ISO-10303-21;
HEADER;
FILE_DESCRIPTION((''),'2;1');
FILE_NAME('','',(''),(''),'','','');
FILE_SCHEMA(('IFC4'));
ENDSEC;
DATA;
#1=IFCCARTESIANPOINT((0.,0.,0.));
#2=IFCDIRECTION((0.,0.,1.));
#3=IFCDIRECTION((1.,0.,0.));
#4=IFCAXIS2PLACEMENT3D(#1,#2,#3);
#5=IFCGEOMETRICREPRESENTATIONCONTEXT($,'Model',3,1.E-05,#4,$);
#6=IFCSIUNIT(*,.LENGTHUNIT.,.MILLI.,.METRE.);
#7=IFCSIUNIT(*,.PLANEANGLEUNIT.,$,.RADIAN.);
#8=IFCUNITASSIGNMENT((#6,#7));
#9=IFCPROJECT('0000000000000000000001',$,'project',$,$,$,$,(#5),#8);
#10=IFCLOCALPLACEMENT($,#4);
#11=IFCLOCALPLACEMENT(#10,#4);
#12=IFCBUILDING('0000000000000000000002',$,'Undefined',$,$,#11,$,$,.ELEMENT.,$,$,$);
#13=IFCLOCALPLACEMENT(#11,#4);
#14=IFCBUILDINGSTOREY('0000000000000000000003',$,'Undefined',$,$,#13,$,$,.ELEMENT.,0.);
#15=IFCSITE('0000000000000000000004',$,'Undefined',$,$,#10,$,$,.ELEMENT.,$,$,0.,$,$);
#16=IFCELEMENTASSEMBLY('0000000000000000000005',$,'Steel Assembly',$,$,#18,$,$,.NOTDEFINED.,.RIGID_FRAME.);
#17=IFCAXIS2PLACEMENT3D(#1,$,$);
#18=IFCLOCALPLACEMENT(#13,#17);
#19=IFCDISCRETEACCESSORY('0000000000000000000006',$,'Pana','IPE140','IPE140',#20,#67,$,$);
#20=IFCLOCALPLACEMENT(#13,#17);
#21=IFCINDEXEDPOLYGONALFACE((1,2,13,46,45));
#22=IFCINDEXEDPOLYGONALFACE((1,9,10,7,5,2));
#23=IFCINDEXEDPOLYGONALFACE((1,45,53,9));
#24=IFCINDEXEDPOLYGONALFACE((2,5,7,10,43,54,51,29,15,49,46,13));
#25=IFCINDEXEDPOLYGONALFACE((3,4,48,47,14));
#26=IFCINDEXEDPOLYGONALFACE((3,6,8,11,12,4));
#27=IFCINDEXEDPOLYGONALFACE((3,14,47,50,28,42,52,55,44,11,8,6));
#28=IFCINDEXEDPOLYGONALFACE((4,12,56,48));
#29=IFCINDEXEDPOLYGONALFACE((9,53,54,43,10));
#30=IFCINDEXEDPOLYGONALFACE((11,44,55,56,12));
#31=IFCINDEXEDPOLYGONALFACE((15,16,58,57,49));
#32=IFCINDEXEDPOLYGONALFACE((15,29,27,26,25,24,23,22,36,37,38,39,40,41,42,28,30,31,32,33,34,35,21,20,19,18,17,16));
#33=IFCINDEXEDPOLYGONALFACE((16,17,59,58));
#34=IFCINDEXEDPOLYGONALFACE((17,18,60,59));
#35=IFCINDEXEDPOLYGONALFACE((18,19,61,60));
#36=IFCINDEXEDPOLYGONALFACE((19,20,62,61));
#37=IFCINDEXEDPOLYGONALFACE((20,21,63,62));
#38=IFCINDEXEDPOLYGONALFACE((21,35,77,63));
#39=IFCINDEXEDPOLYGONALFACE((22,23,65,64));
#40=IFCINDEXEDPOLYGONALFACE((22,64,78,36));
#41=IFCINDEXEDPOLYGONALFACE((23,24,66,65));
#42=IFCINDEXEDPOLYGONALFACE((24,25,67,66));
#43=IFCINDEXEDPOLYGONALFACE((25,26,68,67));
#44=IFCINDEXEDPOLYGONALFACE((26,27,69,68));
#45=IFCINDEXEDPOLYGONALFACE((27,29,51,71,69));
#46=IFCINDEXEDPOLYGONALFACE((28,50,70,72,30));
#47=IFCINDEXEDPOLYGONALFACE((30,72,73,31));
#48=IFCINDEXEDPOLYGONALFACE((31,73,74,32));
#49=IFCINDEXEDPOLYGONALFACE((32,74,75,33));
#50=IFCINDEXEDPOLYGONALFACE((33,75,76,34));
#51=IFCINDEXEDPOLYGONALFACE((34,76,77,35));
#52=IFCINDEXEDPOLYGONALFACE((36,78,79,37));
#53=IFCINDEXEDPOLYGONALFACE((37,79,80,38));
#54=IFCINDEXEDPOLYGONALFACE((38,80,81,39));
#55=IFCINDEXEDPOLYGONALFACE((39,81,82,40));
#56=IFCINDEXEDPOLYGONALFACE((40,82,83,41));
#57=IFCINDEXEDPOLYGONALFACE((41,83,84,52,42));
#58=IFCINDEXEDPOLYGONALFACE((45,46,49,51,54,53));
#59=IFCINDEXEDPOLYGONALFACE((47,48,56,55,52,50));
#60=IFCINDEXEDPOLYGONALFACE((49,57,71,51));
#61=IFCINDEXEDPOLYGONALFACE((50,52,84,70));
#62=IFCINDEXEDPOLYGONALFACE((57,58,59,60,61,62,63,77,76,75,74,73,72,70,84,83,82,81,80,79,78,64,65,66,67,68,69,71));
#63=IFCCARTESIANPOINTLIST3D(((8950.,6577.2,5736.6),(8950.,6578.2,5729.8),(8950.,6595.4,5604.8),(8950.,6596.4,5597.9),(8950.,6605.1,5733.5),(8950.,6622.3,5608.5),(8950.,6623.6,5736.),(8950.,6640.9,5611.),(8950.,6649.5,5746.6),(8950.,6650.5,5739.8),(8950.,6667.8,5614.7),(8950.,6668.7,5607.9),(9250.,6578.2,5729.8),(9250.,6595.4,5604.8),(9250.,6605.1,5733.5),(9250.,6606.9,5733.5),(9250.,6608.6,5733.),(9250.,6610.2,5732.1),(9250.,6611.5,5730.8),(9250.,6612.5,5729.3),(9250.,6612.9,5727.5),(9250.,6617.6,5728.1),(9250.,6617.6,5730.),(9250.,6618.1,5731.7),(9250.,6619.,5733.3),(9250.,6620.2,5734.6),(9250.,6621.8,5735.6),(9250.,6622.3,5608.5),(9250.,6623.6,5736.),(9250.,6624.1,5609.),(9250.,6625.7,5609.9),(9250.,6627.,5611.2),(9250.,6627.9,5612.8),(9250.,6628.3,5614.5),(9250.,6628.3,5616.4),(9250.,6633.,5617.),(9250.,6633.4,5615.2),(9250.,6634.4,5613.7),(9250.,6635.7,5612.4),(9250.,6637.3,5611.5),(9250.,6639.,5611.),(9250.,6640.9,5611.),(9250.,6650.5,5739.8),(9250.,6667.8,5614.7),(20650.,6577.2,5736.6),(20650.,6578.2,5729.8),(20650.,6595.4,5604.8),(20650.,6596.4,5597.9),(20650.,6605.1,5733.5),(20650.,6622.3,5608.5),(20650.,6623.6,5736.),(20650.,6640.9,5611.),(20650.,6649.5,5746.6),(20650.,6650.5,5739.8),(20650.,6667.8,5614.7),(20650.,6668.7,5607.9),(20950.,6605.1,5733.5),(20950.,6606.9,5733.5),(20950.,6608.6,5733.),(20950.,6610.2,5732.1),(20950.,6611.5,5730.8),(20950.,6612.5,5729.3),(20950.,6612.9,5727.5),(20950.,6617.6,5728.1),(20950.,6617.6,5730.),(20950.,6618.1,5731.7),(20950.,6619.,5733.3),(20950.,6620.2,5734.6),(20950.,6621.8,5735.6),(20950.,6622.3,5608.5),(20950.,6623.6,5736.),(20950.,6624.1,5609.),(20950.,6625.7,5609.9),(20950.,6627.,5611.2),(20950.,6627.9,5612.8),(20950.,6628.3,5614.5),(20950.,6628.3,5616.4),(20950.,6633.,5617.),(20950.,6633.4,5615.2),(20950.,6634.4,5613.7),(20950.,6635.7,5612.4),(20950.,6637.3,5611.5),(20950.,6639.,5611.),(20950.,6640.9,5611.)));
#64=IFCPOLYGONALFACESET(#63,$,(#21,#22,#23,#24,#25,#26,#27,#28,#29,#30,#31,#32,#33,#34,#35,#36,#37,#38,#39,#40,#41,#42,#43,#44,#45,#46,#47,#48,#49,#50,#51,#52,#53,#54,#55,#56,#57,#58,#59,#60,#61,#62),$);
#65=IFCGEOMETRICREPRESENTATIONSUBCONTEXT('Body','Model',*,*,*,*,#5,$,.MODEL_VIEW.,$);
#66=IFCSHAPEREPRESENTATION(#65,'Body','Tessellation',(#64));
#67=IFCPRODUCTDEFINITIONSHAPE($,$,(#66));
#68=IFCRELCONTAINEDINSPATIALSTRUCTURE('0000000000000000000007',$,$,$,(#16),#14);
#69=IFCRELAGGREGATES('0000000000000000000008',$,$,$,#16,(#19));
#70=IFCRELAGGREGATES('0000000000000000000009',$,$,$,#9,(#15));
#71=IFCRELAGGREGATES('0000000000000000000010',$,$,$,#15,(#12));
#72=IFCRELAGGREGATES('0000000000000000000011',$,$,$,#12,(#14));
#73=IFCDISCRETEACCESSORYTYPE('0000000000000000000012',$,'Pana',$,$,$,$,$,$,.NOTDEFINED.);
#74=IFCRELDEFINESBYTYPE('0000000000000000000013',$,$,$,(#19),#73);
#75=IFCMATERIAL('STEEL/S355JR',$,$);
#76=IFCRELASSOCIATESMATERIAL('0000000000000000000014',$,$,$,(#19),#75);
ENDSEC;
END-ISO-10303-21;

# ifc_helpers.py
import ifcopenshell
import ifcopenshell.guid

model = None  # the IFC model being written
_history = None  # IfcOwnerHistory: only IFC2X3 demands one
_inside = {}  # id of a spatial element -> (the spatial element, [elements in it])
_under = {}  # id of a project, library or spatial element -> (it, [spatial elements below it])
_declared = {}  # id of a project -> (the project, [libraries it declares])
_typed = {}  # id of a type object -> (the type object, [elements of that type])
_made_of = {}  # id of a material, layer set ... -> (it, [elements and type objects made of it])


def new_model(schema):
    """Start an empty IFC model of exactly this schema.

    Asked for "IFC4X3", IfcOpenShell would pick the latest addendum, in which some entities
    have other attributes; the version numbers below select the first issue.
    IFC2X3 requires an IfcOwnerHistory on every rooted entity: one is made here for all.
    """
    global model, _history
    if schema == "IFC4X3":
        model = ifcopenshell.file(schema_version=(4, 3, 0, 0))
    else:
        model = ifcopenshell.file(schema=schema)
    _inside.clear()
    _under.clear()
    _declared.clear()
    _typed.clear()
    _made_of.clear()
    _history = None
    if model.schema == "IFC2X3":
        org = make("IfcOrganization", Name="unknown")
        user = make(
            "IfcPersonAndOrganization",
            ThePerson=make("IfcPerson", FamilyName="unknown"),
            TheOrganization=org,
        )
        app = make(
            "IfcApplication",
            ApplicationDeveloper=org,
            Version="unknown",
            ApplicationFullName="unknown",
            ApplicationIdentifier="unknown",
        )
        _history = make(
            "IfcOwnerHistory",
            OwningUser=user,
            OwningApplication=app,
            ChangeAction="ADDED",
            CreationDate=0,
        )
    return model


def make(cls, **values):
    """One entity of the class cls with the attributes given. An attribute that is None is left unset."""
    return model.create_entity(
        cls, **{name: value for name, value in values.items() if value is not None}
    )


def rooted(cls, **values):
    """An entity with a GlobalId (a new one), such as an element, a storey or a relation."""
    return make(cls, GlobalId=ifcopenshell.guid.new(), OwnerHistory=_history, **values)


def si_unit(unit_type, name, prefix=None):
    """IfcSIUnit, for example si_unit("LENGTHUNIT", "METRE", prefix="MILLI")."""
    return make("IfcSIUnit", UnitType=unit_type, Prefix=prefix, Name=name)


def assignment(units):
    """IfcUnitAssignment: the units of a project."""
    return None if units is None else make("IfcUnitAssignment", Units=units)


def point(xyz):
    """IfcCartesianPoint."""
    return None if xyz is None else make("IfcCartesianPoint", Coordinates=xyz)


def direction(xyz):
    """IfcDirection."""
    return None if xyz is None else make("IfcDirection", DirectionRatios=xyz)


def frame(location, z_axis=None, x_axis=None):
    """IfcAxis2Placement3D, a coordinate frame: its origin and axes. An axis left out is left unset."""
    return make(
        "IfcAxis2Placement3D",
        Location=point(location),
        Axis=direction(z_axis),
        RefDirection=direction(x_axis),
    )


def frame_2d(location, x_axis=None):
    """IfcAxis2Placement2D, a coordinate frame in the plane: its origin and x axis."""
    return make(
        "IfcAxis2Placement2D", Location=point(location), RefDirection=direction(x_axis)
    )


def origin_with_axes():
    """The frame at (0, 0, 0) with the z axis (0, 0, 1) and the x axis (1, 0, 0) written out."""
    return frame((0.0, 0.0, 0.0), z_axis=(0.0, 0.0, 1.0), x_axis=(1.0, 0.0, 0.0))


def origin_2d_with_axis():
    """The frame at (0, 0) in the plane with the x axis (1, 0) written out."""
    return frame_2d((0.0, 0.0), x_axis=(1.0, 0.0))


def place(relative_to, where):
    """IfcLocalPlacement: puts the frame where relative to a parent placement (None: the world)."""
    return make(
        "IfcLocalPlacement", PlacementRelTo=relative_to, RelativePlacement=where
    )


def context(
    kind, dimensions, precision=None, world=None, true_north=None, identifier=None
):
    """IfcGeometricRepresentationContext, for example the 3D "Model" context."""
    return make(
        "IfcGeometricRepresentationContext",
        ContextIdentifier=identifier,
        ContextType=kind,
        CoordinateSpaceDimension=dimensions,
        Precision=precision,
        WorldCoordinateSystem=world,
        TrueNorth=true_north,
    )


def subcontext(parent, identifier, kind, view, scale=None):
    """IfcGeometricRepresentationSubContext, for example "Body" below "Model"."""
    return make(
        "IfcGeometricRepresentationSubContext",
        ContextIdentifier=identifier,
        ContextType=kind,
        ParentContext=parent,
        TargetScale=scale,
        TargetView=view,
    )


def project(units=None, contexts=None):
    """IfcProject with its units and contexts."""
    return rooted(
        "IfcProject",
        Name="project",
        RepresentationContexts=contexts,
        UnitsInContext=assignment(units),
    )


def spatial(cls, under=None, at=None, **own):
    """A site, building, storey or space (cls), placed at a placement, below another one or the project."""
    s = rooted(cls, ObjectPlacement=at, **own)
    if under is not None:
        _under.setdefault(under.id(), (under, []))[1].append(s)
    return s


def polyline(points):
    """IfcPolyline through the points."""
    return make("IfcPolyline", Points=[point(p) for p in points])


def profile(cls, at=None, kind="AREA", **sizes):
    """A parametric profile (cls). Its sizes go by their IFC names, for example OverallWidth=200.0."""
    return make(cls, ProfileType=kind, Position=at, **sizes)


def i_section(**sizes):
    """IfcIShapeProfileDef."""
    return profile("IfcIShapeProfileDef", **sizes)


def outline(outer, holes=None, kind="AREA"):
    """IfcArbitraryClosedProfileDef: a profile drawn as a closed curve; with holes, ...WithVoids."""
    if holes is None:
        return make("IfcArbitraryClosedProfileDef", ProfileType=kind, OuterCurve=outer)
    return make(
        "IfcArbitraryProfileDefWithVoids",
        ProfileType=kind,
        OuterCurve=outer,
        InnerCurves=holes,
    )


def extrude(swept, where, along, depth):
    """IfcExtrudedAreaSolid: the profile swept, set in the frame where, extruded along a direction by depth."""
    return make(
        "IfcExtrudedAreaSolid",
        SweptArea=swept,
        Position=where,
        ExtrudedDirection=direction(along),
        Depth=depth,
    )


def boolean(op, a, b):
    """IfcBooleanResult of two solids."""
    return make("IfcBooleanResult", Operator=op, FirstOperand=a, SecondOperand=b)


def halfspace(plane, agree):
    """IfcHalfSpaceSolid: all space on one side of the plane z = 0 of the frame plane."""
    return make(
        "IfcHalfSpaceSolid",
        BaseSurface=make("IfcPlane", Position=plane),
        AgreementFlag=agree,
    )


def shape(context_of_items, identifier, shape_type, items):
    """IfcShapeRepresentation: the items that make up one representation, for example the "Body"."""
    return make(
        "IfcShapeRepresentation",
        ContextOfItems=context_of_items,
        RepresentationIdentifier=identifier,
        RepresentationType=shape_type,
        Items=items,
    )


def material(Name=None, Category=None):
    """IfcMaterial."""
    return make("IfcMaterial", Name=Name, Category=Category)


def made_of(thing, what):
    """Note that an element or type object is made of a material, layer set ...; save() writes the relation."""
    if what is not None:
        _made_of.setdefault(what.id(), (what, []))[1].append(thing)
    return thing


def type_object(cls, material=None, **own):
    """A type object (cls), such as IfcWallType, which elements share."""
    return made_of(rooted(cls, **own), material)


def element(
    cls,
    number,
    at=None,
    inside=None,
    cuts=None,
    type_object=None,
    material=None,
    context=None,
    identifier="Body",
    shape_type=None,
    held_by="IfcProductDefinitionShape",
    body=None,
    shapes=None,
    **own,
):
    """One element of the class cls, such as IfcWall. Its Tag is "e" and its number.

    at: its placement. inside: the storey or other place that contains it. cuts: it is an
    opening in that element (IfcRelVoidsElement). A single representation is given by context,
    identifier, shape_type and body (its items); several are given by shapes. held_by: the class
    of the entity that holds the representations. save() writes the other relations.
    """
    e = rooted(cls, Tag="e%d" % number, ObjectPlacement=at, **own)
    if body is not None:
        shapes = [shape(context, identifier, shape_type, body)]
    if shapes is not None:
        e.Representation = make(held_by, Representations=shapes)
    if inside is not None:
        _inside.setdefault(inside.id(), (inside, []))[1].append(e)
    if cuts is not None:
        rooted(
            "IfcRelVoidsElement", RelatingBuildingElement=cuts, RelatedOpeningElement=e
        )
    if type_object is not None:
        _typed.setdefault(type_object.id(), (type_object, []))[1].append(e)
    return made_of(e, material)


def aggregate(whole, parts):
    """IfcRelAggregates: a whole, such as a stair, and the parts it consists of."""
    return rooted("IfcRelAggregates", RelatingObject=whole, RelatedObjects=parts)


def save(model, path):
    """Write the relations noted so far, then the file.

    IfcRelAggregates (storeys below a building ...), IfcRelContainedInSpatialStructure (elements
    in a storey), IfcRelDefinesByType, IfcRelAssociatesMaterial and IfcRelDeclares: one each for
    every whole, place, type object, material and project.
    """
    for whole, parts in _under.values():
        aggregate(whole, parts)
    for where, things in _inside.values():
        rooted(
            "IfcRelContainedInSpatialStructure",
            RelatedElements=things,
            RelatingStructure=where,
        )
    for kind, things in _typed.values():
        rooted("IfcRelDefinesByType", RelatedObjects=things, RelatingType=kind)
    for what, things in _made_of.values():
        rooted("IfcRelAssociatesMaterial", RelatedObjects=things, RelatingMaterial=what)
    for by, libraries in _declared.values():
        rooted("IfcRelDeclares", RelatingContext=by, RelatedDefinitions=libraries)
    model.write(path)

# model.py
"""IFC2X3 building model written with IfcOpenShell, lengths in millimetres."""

from ifc_helpers import new_model, si_unit, frame, origin_with_axes, origin_2d_with_axis, place, context, subcontext, project, spatial, polyline, i_section, outline, extrude, boolean, halfspace, material, type_object, element, aggregate, save


model = new_model("IFC2X3")

# Units and contexts
model_context = context("Model", 3, precision=1e-05, world=origin_with_axes())
body_context = subcontext(model_context, "Body", "Model", "MODEL_VIEW")
ifc_project = project(units=[si_unit("LENGTHUNIT", "METRE", prefix="MILLI"), si_unit("PLANEANGLEUNIT", "RADIAN")], contexts=[model_context])

# Site, building, storey
site_placement = place(None, origin_with_axes())
site = spatial("IfcSite", under=ifc_project, at=site_placement, Name="Undefined", CompositionType="ELEMENT", RefElevation=0.0)
building_placement = place(site_placement, origin_with_axes())
building = spatial("IfcBuilding", under=site, at=building_placement, Name="Undefined", CompositionType="ELEMENT")
storey_placement = place(building_placement, origin_with_axes())
storey = spatial("IfcBuildingStorey", under=building, at=storey_placement, Name="Undefined", CompositionType="ELEMENT", Elevation=0.0)

# Shared definitions
ifc_material_1 = material(Name="STEEL/S355JR")

# Element assembly, discrete accessory
assembly_1_placement = place(storey_placement, origin_with_axes())
assembly_1 = element("IfcElementAssembly", 1, at=assembly_1_placement, inside=storey, Name="Steel Assembly", AssemblyPlace="NOTDEFINED", PredefinedType="RIGID_FRAME")
discrete_accessory_type_1 = type_object("IfcDiscreteAccessoryType", Name="Pana")
discrete_accessory_1_placement = place(assembly_1_placement, frame((20950.0, 6623.0, 5672.3), z_axis=(0.0, -0.136926, 0.990581), x_axis=(-1.0, 0.0, 0.0)))
discrete_accessory_1 = element("IfcDiscreteAccessory", 2, at=discrete_accessory_1_placement, type_object=discrete_accessory_type_1, material=ifc_material_1, Name="Pana", Description="IPE140", ObjectType="IPE140", context=body_context, shape_type="CSG", body=[
    boolean("DIFFERENCE", boolean("DIFFERENCE", boolean("DIFFERENCE", boolean("DIFFERENCE", extrude(i_section(OverallWidth=73.0, OverallDepth=140.0, WebThickness=4.7, FlangeThickness=6.9, FilletRadius=7.0, at=origin_2d_with_axis()), frame((12005.0, 0.0, 0.0), z_axis=(-1.0, 0.0, 0.0), x_axis=(0.0, -1.0, 0.0)), (0.0, 0.0, 1.0), 12010.0), extrude(outline(polyline([(0.0, 0.0), (11.9, 0.0), (11.9, 300.0), (138.1, 300.0), (138.1, 0.0), (150.0, 0.0), (150.0, 305.0), (0.0, 305.0), (0.0, 0.0)])), frame((300.0, -41.5, 75.0), z_axis=(0.0, 1.0, 0.0), x_axis=(0.0, 0.0, -1.0)), (0.0, 0.0, 1.0), 83.0)), extrude(outline(polyline([(0.0, 0.0), (11.9, 0.0), (11.9, 5.0), (-138.1, 5.0), (-138.1, 0.0), (-126.2, 0.0), (-126.2, -300.0), (0.0, -300.0), (0.0, 0.0)])), frame((12000.0, -41.5, 63.1), z_axis=(0.0, 1.0, 0.0), x_axis=(0.0, 0.0, 1.0)), (0.0, 0.0, 1.0), 83.0)), halfspace(frame((12005.0, 0.0, 1070.0), z_axis=(1.0, 0.0, 0.0), x_axis=(0.0, 1.0, 0.0)), False)), halfspace(frame((-5.0, 0.0, 1070.0), z_axis=(1.0, 0.0, 0.0), x_axis=(0.0, 1.0, 0.0)), True)),
])
aggregate(assembly_1, [discrete_accessory_1])

save(model, "model.ifc")
